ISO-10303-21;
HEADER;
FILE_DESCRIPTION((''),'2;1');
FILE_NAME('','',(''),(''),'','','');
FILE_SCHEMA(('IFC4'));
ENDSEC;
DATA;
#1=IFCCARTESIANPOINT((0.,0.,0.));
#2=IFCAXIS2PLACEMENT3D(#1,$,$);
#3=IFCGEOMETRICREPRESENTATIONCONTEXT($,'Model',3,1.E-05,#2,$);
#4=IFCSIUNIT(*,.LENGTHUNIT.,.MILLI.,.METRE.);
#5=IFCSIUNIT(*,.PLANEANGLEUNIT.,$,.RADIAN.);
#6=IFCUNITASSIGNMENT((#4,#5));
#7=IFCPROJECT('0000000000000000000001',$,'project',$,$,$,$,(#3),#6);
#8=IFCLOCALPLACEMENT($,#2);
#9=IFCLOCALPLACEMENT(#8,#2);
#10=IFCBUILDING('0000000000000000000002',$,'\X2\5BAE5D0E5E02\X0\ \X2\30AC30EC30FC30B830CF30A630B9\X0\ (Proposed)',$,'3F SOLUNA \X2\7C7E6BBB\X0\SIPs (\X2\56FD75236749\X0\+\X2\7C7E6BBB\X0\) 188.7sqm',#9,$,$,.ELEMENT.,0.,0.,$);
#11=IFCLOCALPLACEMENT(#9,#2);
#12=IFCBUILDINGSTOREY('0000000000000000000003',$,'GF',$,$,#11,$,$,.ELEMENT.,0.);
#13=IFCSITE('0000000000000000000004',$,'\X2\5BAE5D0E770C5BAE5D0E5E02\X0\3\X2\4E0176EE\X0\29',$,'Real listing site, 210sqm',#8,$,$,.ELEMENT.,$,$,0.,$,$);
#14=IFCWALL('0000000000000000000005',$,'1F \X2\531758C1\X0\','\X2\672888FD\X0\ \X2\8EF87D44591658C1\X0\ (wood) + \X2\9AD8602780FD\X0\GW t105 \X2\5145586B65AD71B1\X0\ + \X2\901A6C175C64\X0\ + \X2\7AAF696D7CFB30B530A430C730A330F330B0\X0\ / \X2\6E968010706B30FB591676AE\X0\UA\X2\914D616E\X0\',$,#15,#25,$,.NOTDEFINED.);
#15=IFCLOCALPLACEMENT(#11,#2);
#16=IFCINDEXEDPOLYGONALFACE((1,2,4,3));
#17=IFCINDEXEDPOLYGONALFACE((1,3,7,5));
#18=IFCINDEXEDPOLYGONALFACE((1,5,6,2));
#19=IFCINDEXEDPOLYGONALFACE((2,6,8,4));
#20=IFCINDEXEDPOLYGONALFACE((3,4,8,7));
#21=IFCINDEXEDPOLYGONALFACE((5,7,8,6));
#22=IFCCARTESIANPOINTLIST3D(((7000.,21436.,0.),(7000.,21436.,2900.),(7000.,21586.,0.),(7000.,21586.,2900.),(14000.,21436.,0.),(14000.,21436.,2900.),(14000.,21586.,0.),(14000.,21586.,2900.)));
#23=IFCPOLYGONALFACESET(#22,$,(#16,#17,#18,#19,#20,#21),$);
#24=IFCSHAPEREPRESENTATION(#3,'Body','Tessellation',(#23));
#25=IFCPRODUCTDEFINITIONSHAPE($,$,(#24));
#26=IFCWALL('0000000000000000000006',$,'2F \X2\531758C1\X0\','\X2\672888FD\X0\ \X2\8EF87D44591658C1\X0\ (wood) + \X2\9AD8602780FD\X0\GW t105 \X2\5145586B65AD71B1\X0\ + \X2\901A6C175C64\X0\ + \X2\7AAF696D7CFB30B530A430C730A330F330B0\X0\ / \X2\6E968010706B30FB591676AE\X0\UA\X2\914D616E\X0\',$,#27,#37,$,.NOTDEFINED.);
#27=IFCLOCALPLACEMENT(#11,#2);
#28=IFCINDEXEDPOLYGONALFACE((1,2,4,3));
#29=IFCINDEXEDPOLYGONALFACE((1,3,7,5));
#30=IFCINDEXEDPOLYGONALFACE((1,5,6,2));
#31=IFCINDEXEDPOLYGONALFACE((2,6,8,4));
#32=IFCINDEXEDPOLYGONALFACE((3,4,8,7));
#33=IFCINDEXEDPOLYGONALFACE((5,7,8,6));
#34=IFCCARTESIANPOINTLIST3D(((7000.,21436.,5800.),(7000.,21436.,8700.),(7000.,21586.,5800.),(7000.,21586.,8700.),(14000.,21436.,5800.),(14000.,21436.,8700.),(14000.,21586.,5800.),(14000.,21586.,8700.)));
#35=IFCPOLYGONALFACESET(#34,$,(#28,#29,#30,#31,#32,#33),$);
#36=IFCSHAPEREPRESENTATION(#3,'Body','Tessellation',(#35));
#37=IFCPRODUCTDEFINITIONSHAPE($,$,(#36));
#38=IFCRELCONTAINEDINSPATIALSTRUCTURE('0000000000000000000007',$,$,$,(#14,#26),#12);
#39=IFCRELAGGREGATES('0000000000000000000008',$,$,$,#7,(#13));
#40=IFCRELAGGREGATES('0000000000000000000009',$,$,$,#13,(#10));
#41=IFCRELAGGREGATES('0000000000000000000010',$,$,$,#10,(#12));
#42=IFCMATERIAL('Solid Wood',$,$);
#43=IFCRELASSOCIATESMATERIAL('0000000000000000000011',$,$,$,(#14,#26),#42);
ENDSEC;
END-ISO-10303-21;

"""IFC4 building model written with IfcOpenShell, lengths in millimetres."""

from ifc_helpers import new_model, si_unit, frame, frame_2d, origin, place, context, project, spatial, rectangle, extrude, material, element, save


model = new_model("IFC4")

# Units and contexts
model_context = context("Model", 3, precision=1e-05, world=origin())
ifc_project = project(units=[si_unit("LENGTHUNIT", "METRE", prefix="MILLI"), si_unit("PLANEANGLEUNIT", "RADIAN")], contexts=[model_context])

# Site, building, storey
site_placement = place(None, origin())
site = spatial("IfcSite", under=ifc_project, at=site_placement, Name="宮崎県宮崎市3丁目29", ObjectType="Real listing site, 210sqm", CompositionType="ELEMENT", RefElevation=0.0)
building_placement = place(site_placement, origin())
building = spatial("IfcBuilding", under=site, at=building_placement, Name="宮崎市 ガレージハウス (Proposed)", ObjectType="3F SOLUNA 籾殻SIPs (国産杉+籾殻) 188.7sqm", CompositionType="ELEMENT", ElevationOfRefHeight=0.0, ElevationOfTerrain=0.0)
storey_placement = place(building_placement, origin())
storey = spatial("IfcBuildingStorey", under=building, at=storey_placement, Name="GF", CompositionType="ELEMENT", Elevation=0.0)

# Shared definitions
ifc_material_1 = material(Name="Solid Wood")

# Wall
wall_1_placement = place(storey_placement, frame((3500.0, 10718.0, 0.0)))
element("IfcWall", 1, at=wall_1_placement, inside=storey, material=ifc_material_1, Name="1F 北壁", Description="木製 軸組外壁 (wood) + 高性能GW t105 充填断熱 + 通気層 + 窯業系サイディング / 準耐火・外皮UA配慮", PredefinedType="NOTDEFINED", context=model_context, shape_type="SweptSolid", body=[
    extrude(rectangle(XDim=7000.0, YDim=150.0, at=frame_2d((3500.0, 75.0))), frame((3500.0, 10718.0, 0.0)), (0.0, 0.0, 1.0), 2900.0),
])

# Wall
wall_2_placement = place(storey_placement, frame((3500.0, 10718.0, 2900.0)))
element("IfcWall", 2, at=wall_2_placement, inside=storey, material=ifc_material_1, Name="2F 北壁", Description="木製 軸組外壁 (wood) + 高性能GW t105 充填断熱 + 通気層 + 窯業系サイディング / 準耐火・外皮UA配慮", PredefinedType="NOTDEFINED", context=model_context, shape_type="SweptSolid", body=[
    extrude(rectangle(XDim=7000.0, YDim=150.0, at=frame_2d((3500.0, 75.0))), frame((3500.0, 10718.0, 2900.0)), (0.0, 0.0, 1.0), 2900.0),
])

save(model, "model.ifc")
